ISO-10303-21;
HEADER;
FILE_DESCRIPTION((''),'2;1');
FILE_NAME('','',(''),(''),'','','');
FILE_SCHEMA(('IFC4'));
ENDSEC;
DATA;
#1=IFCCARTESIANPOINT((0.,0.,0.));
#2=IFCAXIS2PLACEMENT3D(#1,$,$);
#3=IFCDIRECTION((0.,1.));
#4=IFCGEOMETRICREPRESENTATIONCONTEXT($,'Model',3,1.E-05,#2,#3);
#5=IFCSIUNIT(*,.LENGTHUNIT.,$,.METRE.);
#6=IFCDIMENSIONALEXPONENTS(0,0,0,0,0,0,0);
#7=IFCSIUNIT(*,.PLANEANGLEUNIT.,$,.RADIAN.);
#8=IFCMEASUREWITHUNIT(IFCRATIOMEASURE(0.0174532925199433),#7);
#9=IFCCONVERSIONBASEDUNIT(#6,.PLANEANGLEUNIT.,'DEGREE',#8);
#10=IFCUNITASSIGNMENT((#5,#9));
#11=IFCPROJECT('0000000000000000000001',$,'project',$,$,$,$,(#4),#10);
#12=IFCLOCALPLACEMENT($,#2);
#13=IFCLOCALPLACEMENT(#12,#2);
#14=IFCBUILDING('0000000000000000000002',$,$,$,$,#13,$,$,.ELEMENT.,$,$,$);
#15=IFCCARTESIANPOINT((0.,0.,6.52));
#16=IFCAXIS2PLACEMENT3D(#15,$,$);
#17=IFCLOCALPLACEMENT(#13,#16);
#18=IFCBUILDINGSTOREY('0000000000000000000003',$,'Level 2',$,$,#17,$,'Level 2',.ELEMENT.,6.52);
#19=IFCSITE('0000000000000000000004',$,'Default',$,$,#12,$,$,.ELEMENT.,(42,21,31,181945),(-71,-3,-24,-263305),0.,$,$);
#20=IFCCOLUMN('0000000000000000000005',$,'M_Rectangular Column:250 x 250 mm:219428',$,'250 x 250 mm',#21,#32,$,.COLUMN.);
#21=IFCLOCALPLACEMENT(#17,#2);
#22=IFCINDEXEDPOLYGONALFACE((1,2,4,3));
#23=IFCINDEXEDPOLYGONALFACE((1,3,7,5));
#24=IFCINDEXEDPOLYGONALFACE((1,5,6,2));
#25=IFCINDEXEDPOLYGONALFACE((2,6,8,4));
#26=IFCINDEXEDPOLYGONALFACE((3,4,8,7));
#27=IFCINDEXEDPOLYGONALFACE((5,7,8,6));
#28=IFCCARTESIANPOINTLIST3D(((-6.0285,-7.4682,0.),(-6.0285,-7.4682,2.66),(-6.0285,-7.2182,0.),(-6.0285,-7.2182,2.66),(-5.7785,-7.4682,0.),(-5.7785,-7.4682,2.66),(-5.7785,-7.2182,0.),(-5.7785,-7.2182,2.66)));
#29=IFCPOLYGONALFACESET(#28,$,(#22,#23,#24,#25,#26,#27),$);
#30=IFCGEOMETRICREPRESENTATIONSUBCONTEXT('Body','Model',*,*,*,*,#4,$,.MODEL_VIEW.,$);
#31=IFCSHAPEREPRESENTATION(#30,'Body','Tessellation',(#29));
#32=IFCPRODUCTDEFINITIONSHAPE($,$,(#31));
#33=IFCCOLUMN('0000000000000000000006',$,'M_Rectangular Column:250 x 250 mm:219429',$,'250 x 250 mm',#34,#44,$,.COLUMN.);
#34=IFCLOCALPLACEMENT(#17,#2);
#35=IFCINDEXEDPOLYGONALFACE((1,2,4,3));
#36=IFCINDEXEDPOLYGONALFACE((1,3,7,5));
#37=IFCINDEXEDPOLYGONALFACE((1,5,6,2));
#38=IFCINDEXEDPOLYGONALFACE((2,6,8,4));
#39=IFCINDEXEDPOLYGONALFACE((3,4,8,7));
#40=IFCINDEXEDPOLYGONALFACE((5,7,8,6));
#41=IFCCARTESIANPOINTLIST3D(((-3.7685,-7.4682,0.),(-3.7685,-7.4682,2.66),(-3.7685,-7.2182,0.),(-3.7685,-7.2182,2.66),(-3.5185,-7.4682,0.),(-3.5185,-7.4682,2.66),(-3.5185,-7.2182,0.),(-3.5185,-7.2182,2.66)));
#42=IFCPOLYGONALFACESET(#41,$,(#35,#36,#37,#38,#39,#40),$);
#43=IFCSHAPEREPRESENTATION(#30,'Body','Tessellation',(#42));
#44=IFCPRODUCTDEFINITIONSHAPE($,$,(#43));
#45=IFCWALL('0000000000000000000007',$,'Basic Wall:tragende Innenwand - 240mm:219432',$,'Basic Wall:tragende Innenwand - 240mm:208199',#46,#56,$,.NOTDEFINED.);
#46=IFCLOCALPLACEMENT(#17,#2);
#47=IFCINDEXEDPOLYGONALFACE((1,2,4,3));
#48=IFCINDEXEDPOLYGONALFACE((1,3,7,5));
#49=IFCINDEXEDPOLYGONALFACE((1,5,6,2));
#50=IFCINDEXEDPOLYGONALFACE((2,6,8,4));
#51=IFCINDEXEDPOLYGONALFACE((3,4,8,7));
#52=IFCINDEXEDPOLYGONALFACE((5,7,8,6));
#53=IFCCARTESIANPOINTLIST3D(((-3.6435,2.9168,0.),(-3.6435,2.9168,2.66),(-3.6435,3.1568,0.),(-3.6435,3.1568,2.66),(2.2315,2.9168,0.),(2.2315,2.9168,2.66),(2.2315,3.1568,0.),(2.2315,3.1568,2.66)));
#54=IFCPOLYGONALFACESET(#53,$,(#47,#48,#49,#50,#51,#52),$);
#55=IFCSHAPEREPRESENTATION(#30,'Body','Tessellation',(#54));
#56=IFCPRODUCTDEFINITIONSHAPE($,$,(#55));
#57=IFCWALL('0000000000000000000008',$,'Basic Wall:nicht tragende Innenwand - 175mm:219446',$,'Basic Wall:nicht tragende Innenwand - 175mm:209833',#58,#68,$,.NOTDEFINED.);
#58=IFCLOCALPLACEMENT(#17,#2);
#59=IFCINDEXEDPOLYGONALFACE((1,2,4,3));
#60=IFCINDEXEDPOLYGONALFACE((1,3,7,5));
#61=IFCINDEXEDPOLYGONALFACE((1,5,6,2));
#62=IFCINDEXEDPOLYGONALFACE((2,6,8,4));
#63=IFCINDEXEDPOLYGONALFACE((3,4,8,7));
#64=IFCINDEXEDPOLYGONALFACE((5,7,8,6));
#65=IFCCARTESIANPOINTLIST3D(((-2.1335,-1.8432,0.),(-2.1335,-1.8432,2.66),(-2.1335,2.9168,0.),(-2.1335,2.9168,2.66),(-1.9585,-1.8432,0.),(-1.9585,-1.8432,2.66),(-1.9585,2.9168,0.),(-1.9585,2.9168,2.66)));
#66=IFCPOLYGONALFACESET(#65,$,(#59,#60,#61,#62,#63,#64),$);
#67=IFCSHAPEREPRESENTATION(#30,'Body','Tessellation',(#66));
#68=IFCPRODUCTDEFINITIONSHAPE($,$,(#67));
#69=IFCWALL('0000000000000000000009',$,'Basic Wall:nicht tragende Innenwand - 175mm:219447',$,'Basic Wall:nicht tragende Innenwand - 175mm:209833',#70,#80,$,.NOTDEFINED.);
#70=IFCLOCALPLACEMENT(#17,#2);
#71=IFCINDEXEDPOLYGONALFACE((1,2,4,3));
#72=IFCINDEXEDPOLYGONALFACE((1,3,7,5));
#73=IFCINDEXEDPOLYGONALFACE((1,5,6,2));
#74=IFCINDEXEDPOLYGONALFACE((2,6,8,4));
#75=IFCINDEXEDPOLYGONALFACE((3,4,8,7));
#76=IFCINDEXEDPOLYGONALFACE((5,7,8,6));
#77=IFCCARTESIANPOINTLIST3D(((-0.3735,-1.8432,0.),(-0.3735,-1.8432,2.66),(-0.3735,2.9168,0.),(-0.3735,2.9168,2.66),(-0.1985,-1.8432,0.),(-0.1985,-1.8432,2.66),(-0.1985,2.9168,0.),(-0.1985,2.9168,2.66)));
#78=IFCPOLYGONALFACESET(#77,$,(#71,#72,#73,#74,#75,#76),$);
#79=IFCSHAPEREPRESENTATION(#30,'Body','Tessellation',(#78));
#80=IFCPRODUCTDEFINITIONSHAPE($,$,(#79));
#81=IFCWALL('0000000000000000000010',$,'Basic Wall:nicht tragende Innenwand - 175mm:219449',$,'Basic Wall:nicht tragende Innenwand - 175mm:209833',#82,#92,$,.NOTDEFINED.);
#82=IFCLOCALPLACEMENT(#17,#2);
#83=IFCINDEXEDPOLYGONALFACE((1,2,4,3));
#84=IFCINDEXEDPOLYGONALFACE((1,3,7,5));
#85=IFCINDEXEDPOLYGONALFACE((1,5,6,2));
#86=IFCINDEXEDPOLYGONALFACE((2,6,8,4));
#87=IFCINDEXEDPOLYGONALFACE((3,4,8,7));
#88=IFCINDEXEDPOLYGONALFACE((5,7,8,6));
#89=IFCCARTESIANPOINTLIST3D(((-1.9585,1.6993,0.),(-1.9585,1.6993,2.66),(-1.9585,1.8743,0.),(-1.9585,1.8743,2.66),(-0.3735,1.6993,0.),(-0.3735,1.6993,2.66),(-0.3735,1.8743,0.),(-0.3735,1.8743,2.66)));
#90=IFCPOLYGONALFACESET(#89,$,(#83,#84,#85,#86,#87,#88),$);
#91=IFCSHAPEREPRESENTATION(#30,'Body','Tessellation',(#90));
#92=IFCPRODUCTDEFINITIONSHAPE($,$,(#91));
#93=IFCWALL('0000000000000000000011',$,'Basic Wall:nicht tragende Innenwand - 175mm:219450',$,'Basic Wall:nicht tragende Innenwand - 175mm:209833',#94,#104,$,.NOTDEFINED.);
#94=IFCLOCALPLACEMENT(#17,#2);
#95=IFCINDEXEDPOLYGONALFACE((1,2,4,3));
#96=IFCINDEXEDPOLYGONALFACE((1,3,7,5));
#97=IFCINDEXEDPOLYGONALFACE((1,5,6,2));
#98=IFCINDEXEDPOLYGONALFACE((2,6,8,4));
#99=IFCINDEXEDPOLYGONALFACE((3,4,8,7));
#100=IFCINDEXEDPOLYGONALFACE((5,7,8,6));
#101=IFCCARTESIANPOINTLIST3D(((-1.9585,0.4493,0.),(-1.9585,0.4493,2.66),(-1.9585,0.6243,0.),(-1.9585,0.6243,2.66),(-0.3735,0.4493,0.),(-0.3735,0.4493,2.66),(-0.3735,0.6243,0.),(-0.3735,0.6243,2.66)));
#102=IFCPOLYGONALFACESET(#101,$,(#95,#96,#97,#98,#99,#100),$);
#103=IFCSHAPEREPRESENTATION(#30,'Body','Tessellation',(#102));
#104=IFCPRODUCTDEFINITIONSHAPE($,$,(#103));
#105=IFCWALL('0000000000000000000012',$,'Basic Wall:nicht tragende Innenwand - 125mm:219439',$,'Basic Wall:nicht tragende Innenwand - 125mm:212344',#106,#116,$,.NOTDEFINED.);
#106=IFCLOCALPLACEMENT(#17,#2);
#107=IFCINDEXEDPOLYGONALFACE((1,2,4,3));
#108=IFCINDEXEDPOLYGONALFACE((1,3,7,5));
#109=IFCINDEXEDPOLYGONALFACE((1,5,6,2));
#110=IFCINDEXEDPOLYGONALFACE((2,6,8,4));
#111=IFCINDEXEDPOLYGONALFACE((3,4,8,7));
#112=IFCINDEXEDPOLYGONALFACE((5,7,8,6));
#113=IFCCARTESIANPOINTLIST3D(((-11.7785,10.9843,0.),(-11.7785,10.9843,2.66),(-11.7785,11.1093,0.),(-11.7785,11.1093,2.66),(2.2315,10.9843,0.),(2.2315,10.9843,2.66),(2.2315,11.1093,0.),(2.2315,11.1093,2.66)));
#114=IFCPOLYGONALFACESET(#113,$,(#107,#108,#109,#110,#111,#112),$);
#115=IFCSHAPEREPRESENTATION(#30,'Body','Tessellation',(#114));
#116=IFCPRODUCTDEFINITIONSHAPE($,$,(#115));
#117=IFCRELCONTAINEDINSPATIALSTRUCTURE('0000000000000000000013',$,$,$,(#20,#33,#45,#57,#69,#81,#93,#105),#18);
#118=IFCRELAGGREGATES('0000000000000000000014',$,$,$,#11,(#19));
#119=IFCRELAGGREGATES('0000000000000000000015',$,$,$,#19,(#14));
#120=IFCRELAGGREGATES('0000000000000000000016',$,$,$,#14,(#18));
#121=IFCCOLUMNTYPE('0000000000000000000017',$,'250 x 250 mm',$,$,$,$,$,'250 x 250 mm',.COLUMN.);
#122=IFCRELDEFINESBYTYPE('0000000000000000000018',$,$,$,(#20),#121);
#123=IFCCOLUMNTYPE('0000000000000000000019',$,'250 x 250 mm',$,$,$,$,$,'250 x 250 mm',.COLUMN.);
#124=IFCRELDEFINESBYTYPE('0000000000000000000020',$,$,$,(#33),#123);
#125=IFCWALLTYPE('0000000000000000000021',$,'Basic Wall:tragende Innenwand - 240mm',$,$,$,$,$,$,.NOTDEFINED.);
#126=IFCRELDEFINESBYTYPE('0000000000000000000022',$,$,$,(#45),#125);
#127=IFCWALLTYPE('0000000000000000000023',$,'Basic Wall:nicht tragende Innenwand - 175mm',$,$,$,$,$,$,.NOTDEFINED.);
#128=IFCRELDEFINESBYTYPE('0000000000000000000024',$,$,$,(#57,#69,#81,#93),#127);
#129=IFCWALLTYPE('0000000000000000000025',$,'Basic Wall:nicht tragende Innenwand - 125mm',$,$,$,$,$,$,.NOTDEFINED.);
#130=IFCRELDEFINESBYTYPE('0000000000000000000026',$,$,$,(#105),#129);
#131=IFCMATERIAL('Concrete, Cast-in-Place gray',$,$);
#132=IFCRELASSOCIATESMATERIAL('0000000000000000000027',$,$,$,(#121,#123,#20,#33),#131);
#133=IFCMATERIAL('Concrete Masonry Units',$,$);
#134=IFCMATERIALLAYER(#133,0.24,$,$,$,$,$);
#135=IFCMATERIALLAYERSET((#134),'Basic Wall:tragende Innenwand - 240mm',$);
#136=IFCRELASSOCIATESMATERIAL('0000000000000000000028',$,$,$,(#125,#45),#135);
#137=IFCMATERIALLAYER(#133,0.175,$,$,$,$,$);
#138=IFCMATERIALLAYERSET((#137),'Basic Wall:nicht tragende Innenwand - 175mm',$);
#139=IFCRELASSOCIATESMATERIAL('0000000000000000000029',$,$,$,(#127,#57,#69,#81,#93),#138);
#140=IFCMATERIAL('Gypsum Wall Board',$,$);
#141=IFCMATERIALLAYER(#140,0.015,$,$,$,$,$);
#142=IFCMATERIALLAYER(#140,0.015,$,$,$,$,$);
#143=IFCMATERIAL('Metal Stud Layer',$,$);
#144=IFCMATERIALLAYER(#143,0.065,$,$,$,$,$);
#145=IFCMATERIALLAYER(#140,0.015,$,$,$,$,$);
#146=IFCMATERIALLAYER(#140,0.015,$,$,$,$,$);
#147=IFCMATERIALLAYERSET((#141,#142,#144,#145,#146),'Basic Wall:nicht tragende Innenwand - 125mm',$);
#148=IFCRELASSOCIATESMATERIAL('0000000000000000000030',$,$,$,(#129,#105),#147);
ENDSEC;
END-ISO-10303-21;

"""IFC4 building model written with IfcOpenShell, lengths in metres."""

from ifc_helpers import new_model, entity, si_unit, converted_unit, direction, frame, frame_2d, origin, place, context, subcontext, project, spatial, rectangle, extrude, source, transform, mapped, material, layer, layer_set, layer_usage, material_profile, profile_set, profile_usage, type_object, type_shapes, element, save


model = new_model("IFC4")

# Units and contexts
model_context = context("Model", 3, precision=1e-05, world=origin(), true_north=direction((0.0, 1.0)))
body_context = subcontext(model_context, "Body", "Model", "MODEL_VIEW")
ifc_project = project(units=[si_unit("LENGTHUNIT", "METRE"), converted_unit("PLANEANGLEUNIT", "DEGREE", entity("IfcRatioMeasure", 0.0174532925199433), si_unit("PLANEANGLEUNIT", "RADIAN"), dimensions=[0, 0, 0, 0, 0, 0, 0])], contexts=[model_context])

# Site, building, storey
site_placement = place(None, origin())
site = spatial("IfcSite", under=ifc_project, at=site_placement, Name="Default", CompositionType="ELEMENT", RefLatitude=(42, 21, 31, 181945), RefLongitude=(-71, -3, -24, -263305), RefElevation=0.0)
building_placement = place(site_placement, origin())
building = spatial("IfcBuilding", under=site, at=building_placement, CompositionType="ELEMENT")
storey_placement = place(building_placement, frame((0.0, 0.0, 6.52)))
storey = spatial("IfcBuildingStorey", under=building, at=storey_placement, Name="Level 2", LongName="Level 2", CompositionType="ELEMENT", Elevation=6.52)

# Columns
ifc_material_1 = material(Name="Concrete, Cast-in-Place gray")
ifc_material_profile = material_profile(ifc_material_1, rectangle(XDim=0.25, YDim=0.25, at=frame_2d((0.0, 0.0), x_axis=(1.0, 0.0))))
ifc_profile_set = profile_set([ifc_material_profile], Name="250 x 250 mm")
ifc_profile_usage_1 = profile_usage(ifc_profile_set)
column_type_1 = type_object("IfcColumnType", Name="250 x 250 mm", ElementType="250 x 250 mm", PredefinedType="COLUMN", material=ifc_profile_set)
shared_shape_1 = source(origin(), body_context, "Body", "SweptSolid", [
    extrude(rectangle(XDim=0.25, YDim=0.25, at=frame_2d((0.0, 0.0), x_axis=(1.0, 0.0))), frame((-5.9035, -7.3432, 6.52), z_axis=(0.0, 0.0, 1.0), x_axis=(0.0, -1.0, 0.0)), (0.0, 0.0, 1.0), 2.66),
])
type_shapes(column_type_1, [shared_shape_1])
column_1_placement = place(storey_placement, frame((0.0, 0.0, -6.52)))
element("IfcColumn", 1, at=column_1_placement, inside=storey, type_object=column_type_1, material=ifc_profile_usage_1, Name="M_Rectangular Column:250 x 250 mm:219428", ObjectType="250 x 250 mm", PredefinedType="COLUMN", context=body_context, shape_type="MappedRepresentation", body=[
    mapped(shared_shape_1, transform((0.0, 0.0, 0.0), scale=1.0)),
])
ifc_profile_usage_2 = profile_usage(ifc_profile_set)
column_type_2 = type_object("IfcColumnType", Name="250 x 250 mm", ElementType="250 x 250 mm", PredefinedType="COLUMN", material=ifc_profile_set)
shared_shape_2 = source(origin(), body_context, "Body", "SweptSolid", [
    extrude(rectangle(XDim=0.25, YDim=0.25, at=frame_2d((0.0, 0.0), x_axis=(1.0, 0.0))), frame((-3.6435, -7.3432, 6.52), z_axis=(0.0, 0.0, 1.0), x_axis=(0.0, -1.0, 0.0)), (0.0, 0.0, 1.0), 2.66),
])
type_shapes(column_type_2, [shared_shape_2])
column_2_placement = place(storey_placement, frame((0.0, 0.0, -6.52)))
element("IfcColumn", 2, at=column_2_placement, inside=storey, type_object=column_type_2, material=ifc_profile_usage_2, Name="M_Rectangular Column:250 x 250 mm:219429", ObjectType="250 x 250 mm", PredefinedType="COLUMN", context=body_context, shape_type="MappedRepresentation", body=[
    mapped(shared_shape_2, transform((0.0, 0.0, 0.0), scale=1.0)),
])

# Walls
ifc_material_2 = material(Name="Concrete Masonry Units")
ifc_layer_1 = layer(ifc_material_2, 0.24)
ifc_layer_set_1 = layer_set([ifc_layer_1], Name="Basic Wall:tragende Innenwand - 240mm")
ifc_layer_usage_1 = layer_usage(ifc_layer_set_1, "AXIS2", "NEGATIVE", 0.12)
wall_type_1 = type_object("IfcWallType", Name="Basic Wall:tragende Innenwand - 240mm", PredefinedType="NOTDEFINED", material=ifc_layer_set_1)
wall_1_placement = place(storey_placement, frame((2.2315, 3.0368, 0.0), z_axis=(0.0, 0.0, 1.0), x_axis=(-1.0, 0.0, 0.0)))
element("IfcWall", 3, at=wall_1_placement, inside=storey, type_object=wall_type_1, material=ifc_layer_usage_1, Name="Basic Wall:tragende Innenwand - 240mm:219432", ObjectType="Basic Wall:tragende Innenwand - 240mm:208199", PredefinedType="NOTDEFINED", context=body_context, shape_type="SweptSolid", body=[
    extrude(rectangle(XDim=5.875, YDim=0.24, at=frame_2d((2.9375, 0.0), x_axis=(-1.0, 0.0))), origin(), (0.0, 0.0, 1.0), 2.66),
])
ifc_layer_2 = layer(ifc_material_2, 0.175)
ifc_layer_set_2 = layer_set([ifc_layer_2], Name="Basic Wall:nicht tragende Innenwand - 175mm")
ifc_layer_usage_2 = layer_usage(ifc_layer_set_2, "AXIS2", "NEGATIVE", 0.0875)
wall_type_2 = type_object("IfcWallType", Name="Basic Wall:nicht tragende Innenwand - 175mm", PredefinedType="NOTDEFINED", material=ifc_layer_set_2)
wall_2_placement = place(storey_placement, frame((-2.046, 2.9168, 0.0), z_axis=(0.0, 0.0, 1.0), x_axis=(0.0, -1.0, 0.0)))
element("IfcWall", 4, at=wall_2_placement, inside=storey, type_object=wall_type_2, material=ifc_layer_usage_2, Name="Basic Wall:nicht tragende Innenwand - 175mm:219446", ObjectType="Basic Wall:nicht tragende Innenwand - 175mm:209833", PredefinedType="NOTDEFINED", context=body_context, shape_type="SweptSolid", body=[
    extrude(rectangle(XDim=4.76, YDim=0.175, at=frame_2d((2.38, 0.0), x_axis=(-1.0, 0.0))), origin(), (0.0, 0.0, 1.0), 2.66),
])
ifc_layer_usage_3 = layer_usage(ifc_layer_set_2, "AXIS2", "NEGATIVE", 0.0875)
wall_3_placement = place(storey_placement, frame((-0.286, 2.9168, 0.0), z_axis=(0.0, 0.0, 1.0), x_axis=(0.0, -1.0, 0.0)))
element("IfcWall", 5, at=wall_3_placement, inside=storey, type_object=wall_type_2, material=ifc_layer_usage_3, Name="Basic Wall:nicht tragende Innenwand - 175mm:219447", ObjectType="Basic Wall:nicht tragende Innenwand - 175mm:209833", PredefinedType="NOTDEFINED", context=body_context, shape_type="SweptSolid", body=[
    extrude(rectangle(XDim=4.76, YDim=0.175, at=frame_2d((2.38, 0.0), x_axis=(-1.0, 0.0))), origin(), (0.0, 0.0, 1.0), 2.66),
])
ifc_layer_usage_4 = layer_usage(ifc_layer_set_2, "AXIS2", "POSITIVE", -0.0875)
wall_4_placement = place(storey_placement, frame((-1.9585, 1.7868, 0.0)))
element("IfcWall", 6, at=wall_4_placement, inside=storey, type_object=wall_type_2, material=ifc_layer_usage_4, Name="Basic Wall:nicht tragende Innenwand - 175mm:219449", ObjectType="Basic Wall:nicht tragende Innenwand - 175mm:209833", PredefinedType="NOTDEFINED", context=body_context, shape_type="SweptSolid", body=[
    extrude(rectangle(XDim=1.585, YDim=0.175, at=frame_2d((0.7925, 0.0), x_axis=(-1.0, 0.0))), origin(), (0.0, 0.0, 1.0), 2.66),
])
ifc_layer_usage_5 = layer_usage(ifc_layer_set_2, "AXIS2", "POSITIVE", -0.0875)
wall_5_placement = place(storey_placement, frame((-1.9585, 0.5368, 0.0)))
element("IfcWall", 7, at=wall_5_placement, inside=storey, type_object=wall_type_2, material=ifc_layer_usage_5, Name="Basic Wall:nicht tragende Innenwand - 175mm:219450", ObjectType="Basic Wall:nicht tragende Innenwand - 175mm:209833", PredefinedType="NOTDEFINED", context=body_context, shape_type="SweptSolid", body=[
    extrude(rectangle(XDim=1.585, YDim=0.175, at=frame_2d((0.7925, 0.0), x_axis=(-1.0, 0.0))), origin(), (0.0, 0.0, 1.0), 2.66),
])
ifc_material_3 = material(Name="Gypsum Wall Board")
ifc_layer_3 = layer(ifc_material_3, 0.015)
ifc_layer_4 = layer(ifc_material_3, 0.015)
ifc_material_4 = material(Name="Metal Stud Layer")
ifc_layer_5 = layer(ifc_material_4, 0.065)
ifc_layer_6 = layer(ifc_material_3, 0.015)
ifc_layer_7 = layer(ifc_material_3, 0.015)
ifc_layer_set_3 = layer_set([ifc_layer_3, ifc_layer_4, ifc_layer_5, ifc_layer_6, ifc_layer_7], Name="Basic Wall:nicht tragende Innenwand - 125mm")
ifc_layer_usage_6 = layer_usage(ifc_layer_set_3, "AXIS2", "NEGATIVE", 0.0625)
wall_type_3 = type_object("IfcWallType", Name="Basic Wall:nicht tragende Innenwand - 125mm", PredefinedType="NOTDEFINED", material=ifc_layer_set_3)
wall_6_placement = place(storey_placement, frame((2.2315, 11.0468, 0.0), z_axis=(0.0, 0.0, 1.0), x_axis=(-1.0, 0.0, 0.0)))
element("IfcWall", 8, at=wall_6_placement, inside=storey, type_object=wall_type_3, material=ifc_layer_usage_6, Name="Basic Wall:nicht tragende Innenwand - 125mm:219439", ObjectType="Basic Wall:nicht tragende Innenwand - 125mm:212344", PredefinedType="NOTDEFINED", context=body_context, shape_type="SweptSolid", body=[
    extrude(rectangle(XDim=14.01, YDim=0.125, at=frame_2d((7.005, 0.0), x_axis=(-1.0, 0.0))), origin(), (0.0, 0.0, 1.0), 2.66),
])

save(model, "model.ifc")
